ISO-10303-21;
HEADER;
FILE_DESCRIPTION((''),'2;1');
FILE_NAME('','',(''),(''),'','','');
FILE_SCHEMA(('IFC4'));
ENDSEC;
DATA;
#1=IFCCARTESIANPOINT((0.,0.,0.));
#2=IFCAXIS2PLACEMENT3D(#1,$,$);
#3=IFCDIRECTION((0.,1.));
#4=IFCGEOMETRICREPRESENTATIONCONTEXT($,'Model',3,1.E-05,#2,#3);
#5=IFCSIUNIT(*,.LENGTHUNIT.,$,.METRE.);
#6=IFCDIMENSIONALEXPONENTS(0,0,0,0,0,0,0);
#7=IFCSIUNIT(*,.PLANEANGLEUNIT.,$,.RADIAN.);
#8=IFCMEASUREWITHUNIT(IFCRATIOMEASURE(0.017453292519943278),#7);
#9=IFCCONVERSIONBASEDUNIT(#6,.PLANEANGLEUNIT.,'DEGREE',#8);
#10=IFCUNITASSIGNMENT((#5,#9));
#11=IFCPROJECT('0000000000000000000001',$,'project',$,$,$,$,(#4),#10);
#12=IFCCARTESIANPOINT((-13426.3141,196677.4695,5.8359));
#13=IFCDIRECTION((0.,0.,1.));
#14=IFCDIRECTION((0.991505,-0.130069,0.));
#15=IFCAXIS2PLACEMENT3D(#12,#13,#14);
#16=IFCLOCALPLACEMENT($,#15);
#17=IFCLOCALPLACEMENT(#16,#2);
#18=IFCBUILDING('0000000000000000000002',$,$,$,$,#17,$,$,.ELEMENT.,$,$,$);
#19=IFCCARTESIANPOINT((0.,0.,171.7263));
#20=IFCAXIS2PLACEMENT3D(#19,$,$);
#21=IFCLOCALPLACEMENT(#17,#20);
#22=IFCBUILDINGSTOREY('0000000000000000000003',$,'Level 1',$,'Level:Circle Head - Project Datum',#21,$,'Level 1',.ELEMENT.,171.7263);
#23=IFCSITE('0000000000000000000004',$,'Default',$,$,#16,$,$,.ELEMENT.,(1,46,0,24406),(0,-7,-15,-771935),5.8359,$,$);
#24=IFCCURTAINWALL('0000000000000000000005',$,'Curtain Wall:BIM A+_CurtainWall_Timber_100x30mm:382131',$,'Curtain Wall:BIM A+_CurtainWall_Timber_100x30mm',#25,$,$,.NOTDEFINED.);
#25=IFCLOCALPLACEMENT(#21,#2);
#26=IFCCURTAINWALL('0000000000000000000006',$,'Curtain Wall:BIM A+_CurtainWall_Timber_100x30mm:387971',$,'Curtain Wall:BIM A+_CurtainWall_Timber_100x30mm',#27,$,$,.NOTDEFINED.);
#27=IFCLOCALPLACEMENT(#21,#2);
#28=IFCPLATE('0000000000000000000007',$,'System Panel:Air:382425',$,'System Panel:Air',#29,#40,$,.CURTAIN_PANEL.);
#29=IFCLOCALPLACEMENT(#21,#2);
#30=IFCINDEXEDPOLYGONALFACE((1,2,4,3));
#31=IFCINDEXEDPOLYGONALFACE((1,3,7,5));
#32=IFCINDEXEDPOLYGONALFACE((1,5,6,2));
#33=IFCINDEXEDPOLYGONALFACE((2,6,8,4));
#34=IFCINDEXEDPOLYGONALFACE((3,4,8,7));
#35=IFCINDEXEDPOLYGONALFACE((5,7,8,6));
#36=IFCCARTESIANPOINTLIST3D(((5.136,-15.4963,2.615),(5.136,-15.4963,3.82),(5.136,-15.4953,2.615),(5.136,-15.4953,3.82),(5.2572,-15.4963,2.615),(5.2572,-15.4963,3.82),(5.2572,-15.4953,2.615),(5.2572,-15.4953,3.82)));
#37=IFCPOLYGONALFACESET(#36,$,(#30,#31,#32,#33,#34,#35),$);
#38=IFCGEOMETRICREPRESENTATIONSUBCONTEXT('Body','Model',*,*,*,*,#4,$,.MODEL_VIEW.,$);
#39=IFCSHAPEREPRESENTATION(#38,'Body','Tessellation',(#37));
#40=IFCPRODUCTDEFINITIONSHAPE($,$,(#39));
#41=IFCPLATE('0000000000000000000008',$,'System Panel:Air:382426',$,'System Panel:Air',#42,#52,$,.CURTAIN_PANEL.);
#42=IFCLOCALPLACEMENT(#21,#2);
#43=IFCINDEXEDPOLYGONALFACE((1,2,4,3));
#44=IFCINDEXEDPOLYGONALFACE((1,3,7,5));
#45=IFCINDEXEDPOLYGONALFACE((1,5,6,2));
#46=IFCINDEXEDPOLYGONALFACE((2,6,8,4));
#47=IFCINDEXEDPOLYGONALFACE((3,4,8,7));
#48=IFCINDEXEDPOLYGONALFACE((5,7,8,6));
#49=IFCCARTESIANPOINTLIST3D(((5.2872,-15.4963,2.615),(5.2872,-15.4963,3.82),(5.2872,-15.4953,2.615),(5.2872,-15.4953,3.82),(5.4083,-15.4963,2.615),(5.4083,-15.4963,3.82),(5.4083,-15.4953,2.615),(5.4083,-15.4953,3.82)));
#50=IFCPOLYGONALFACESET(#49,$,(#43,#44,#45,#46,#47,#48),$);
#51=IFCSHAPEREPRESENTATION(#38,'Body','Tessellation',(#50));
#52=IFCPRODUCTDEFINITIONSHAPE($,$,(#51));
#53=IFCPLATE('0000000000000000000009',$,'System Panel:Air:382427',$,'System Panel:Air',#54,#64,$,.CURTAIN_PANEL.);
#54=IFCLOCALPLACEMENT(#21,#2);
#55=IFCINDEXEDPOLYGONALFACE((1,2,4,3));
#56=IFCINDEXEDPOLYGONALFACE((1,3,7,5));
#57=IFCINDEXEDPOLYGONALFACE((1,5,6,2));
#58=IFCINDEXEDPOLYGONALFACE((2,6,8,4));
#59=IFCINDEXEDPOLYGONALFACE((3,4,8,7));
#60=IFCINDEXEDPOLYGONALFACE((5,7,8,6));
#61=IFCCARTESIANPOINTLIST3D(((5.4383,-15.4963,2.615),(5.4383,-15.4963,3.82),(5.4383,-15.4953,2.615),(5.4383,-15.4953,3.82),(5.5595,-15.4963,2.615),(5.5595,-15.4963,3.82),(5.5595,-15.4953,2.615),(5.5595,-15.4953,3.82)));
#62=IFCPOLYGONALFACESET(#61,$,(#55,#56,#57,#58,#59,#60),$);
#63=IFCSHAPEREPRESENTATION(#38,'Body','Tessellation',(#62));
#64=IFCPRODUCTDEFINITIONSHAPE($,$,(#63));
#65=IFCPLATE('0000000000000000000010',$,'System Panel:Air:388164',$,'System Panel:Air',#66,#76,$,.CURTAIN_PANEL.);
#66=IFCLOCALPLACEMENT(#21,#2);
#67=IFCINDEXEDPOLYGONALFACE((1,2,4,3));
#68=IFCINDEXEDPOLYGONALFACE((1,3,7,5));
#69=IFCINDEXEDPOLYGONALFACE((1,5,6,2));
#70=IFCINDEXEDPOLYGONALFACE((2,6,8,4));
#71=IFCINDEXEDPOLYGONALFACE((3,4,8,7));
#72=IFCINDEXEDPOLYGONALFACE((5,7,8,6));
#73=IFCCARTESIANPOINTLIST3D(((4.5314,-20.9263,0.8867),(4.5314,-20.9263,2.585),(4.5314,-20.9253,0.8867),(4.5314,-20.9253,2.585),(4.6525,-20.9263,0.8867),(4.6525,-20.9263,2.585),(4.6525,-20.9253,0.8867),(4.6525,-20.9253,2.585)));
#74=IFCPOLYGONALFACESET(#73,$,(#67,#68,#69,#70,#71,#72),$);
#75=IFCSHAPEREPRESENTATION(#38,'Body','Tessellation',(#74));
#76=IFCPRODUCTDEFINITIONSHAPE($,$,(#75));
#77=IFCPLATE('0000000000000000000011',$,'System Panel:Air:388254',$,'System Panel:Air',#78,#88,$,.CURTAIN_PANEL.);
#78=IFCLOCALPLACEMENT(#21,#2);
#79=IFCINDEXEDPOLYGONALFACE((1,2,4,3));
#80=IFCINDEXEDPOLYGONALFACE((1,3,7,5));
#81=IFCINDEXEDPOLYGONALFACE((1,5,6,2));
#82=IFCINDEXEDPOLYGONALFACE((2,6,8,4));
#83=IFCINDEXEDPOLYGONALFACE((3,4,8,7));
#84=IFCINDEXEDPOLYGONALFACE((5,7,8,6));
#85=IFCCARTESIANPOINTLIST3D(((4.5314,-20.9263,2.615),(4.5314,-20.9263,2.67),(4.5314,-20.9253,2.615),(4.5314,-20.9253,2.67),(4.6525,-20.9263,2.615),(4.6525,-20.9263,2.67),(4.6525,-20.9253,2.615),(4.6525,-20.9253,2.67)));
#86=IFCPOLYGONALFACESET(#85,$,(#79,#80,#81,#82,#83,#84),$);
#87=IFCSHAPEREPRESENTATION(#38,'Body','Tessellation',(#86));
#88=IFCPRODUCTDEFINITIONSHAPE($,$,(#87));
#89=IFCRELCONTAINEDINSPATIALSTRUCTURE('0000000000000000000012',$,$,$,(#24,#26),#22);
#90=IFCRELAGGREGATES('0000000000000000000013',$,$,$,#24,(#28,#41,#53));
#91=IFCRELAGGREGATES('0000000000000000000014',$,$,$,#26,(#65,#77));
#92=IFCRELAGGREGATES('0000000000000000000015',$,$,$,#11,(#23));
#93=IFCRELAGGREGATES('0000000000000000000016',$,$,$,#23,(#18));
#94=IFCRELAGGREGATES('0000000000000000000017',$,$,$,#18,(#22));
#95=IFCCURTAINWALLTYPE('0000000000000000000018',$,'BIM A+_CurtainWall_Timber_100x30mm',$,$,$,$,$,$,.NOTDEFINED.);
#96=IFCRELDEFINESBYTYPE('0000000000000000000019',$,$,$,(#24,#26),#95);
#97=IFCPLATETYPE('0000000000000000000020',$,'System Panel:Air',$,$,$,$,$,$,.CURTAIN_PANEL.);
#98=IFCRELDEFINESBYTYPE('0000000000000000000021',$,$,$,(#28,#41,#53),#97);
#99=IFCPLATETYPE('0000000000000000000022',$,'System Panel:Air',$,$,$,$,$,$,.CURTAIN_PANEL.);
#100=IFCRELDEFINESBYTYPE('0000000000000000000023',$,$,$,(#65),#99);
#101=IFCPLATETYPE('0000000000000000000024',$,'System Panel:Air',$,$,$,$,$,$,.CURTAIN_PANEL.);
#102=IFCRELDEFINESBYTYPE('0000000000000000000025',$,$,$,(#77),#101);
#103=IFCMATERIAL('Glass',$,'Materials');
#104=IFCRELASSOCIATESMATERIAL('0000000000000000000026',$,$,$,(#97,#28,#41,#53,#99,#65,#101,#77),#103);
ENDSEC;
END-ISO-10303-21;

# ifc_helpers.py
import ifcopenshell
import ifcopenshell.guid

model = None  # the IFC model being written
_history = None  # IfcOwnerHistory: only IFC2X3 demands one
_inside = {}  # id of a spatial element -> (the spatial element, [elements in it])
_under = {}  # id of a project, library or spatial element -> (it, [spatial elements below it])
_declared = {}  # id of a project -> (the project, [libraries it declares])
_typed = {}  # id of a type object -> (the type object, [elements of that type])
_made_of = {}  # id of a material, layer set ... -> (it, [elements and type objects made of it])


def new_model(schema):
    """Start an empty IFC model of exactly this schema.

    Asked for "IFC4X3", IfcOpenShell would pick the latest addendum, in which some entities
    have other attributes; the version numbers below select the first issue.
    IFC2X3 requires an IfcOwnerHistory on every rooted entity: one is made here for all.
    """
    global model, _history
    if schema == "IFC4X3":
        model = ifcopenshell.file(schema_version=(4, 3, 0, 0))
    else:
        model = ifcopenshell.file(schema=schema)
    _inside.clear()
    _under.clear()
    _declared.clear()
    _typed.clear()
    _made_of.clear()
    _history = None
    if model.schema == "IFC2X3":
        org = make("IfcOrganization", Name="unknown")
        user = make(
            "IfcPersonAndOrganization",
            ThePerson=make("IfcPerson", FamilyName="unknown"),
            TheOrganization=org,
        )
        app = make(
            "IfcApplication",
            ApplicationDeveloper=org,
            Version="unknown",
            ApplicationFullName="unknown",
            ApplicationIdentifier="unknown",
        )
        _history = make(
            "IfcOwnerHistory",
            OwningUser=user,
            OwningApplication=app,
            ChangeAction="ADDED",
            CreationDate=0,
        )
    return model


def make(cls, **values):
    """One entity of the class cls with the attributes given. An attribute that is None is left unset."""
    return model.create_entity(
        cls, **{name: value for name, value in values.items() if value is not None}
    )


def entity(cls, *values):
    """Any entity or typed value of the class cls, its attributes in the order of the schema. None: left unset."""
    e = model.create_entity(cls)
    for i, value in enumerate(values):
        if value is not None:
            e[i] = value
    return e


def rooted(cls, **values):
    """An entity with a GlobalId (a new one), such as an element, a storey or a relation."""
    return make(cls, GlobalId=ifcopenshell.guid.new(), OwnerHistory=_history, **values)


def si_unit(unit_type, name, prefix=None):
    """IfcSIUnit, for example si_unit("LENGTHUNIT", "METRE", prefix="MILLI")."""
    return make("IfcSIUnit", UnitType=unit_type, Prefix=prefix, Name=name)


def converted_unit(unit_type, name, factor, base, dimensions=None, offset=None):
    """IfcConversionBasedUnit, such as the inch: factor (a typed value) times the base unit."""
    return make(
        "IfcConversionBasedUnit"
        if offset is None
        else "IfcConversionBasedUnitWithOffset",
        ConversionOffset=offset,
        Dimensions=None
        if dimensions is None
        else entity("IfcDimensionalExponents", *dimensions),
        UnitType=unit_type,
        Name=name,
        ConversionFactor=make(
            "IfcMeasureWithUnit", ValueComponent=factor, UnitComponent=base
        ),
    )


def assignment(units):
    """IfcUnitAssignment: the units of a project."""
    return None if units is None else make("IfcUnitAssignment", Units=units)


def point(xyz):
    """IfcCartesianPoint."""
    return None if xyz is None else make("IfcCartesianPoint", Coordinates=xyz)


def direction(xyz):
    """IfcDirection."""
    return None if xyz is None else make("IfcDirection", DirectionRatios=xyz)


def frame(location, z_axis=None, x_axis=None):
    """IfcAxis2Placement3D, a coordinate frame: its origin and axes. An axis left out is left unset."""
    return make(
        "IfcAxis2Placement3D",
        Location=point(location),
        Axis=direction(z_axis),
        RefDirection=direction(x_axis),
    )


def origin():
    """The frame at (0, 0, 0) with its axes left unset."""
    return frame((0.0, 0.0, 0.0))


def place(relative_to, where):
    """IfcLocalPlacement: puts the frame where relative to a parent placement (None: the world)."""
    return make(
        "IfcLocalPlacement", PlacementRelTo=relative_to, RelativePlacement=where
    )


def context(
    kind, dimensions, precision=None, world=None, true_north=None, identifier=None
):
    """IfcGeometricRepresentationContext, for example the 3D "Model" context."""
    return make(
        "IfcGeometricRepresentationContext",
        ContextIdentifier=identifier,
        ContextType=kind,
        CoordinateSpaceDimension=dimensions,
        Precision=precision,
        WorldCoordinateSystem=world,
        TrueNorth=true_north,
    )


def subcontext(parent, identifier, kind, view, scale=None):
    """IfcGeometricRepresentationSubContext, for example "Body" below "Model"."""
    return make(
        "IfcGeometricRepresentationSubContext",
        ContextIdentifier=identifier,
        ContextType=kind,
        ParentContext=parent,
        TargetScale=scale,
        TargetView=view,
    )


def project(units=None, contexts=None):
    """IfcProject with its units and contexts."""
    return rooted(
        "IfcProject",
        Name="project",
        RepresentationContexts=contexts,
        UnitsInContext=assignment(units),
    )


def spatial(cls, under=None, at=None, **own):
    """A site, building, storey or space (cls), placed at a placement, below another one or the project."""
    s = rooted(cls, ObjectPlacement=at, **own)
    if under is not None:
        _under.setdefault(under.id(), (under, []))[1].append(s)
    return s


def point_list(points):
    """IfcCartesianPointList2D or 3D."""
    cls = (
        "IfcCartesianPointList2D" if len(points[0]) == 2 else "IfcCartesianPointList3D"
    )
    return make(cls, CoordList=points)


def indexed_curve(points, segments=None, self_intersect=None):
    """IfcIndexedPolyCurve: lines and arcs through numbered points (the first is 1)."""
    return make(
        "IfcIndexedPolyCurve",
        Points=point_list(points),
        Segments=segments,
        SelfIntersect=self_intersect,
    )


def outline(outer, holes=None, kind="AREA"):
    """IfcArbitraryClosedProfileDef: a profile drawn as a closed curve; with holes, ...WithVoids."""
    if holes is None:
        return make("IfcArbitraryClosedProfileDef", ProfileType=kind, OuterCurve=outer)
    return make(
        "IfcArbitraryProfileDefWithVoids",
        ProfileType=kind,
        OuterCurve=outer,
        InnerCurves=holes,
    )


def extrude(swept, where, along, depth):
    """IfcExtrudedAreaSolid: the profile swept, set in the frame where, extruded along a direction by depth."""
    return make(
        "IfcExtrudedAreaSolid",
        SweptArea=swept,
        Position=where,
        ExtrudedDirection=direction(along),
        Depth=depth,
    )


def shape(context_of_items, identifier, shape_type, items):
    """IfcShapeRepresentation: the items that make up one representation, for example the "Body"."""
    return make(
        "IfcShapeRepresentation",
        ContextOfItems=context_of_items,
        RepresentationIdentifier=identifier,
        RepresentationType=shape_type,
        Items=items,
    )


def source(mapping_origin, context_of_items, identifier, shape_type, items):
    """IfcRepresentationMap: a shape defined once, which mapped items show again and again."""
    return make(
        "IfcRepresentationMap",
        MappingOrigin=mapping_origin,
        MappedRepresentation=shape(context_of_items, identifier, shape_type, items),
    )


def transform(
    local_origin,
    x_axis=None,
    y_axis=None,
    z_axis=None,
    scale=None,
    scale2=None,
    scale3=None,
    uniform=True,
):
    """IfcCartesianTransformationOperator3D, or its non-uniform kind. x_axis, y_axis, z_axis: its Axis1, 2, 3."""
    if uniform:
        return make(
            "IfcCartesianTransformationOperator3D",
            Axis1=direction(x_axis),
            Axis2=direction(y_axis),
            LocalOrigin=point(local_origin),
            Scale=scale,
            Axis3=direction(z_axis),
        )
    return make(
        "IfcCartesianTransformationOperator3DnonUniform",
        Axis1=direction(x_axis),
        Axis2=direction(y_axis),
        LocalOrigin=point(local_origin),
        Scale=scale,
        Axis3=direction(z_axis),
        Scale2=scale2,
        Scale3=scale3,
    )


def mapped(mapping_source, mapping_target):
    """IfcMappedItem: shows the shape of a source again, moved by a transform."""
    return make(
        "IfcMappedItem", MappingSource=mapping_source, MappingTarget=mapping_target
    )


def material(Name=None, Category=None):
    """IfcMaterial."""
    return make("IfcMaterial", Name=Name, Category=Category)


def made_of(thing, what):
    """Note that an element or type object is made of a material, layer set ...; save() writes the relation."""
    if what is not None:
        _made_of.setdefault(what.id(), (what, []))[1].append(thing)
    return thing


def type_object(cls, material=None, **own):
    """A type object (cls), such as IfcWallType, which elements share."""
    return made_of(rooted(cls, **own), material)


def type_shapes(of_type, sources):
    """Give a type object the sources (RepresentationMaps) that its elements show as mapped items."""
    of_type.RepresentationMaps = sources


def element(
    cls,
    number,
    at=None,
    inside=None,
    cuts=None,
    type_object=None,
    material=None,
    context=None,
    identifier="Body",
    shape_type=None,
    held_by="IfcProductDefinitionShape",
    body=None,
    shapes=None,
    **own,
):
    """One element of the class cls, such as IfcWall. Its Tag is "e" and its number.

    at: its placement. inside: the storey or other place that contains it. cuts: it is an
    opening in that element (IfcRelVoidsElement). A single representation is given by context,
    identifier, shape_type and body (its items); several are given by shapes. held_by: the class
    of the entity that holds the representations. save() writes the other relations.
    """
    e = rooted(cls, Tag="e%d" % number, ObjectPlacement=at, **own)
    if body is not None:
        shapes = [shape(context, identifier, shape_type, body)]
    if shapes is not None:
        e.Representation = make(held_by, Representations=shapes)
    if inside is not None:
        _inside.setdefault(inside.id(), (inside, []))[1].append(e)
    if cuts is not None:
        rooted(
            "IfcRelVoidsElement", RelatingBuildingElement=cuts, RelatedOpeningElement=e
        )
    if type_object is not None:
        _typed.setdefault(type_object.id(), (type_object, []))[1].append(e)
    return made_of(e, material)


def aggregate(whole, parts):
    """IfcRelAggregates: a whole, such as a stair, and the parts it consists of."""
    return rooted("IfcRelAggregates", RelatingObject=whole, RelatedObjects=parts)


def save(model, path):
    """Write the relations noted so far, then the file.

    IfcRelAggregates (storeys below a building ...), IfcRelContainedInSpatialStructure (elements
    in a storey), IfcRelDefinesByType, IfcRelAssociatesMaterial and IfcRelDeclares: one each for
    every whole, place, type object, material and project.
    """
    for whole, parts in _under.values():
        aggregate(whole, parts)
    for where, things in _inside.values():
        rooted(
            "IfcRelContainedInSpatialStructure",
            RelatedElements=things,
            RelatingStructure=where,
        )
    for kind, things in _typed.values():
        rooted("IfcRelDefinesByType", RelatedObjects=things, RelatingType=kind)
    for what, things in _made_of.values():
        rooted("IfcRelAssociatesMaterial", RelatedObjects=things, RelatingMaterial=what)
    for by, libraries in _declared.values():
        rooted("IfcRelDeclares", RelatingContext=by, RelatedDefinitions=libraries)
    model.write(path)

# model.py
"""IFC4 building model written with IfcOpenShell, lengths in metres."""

from ifc_helpers import new_model, entity, si_unit, converted_unit, direction, frame, origin, place, context, subcontext, project, spatial, indexed_curve, outline, extrude, source, transform, mapped, material, type_object, type_shapes, element, aggregate, save


model = new_model("IFC4")

# Units and contexts
model_context = context("Model", 3, precision=1e-05, world=origin(), true_north=direction((0.0, 1.0)))
body_context = subcontext(model_context, "Body", "Model", "MODEL_VIEW")
ifc_project = project(units=[si_unit("LENGTHUNIT", "METRE"), converted_unit("PLANEANGLEUNIT", "DEGREE", entity("IfcRatioMeasure", 0.017453292519943278), si_unit("PLANEANGLEUNIT", "RADIAN"), dimensions=[0, 0, 0, 0, 0, 0, 0])], contexts=[model_context])

# Site, building, storey
site_placement = place(None, frame((-13426.3141, 196677.4695, 5.8359), z_axis=(0.0, 0.0, 1.0), x_axis=(0.991505, -0.130069, 0.0)))
site = spatial("IfcSite", under=ifc_project, at=site_placement, Name="Default", CompositionType="ELEMENT", RefLatitude=(1, 46, 0, 24406), RefLongitude=(0, -7, -15, -771935), RefElevation=5.8359)
building_placement = place(site_placement, origin())
building = spatial("IfcBuilding", under=site, at=building_placement, CompositionType="ELEMENT")
storey_placement = place(building_placement, frame((0.0, 0.0, 171.7263)))
storey = spatial("IfcBuildingStorey", under=building, at=storey_placement, Name="Level 1", ObjectType="Level:Circle Head - Project Datum", LongName="Level 1", CompositionType="ELEMENT", Elevation=171.7263)

# Curtain walls
curtain_wall_type_1 = type_object("IfcCurtainWallType", Name="BIM A+_CurtainWall_Timber_100x30mm", PredefinedType="NOTDEFINED")
curtain_wall_1_placement = place(storey_placement, frame((0.0, 0.0, -171.7263)))
curtain_wall_1 = element("IfcCurtainWall", 1, at=curtain_wall_1_placement, inside=storey, type_object=curtain_wall_type_1, Name="Curtain Wall:BIM A+_CurtainWall_Timber_100x30mm:382131", ObjectType="Curtain Wall:BIM A+_CurtainWall_Timber_100x30mm", PredefinedType="NOTDEFINED")
curtain_wall_2_placement = place(storey_placement, frame((0.0, 0.0, -171.7263)))
curtain_wall_2 = element("IfcCurtainWall", 2, at=curtain_wall_2_placement, inside=storey, type_object=curtain_wall_type_1, Name="Curtain Wall:BIM A+_CurtainWall_Timber_100x30mm:387971", ObjectType="Curtain Wall:BIM A+_CurtainWall_Timber_100x30mm", PredefinedType="NOTDEFINED")

# Plates
ifc_material_1 = material(Name="Glass", Category="Materials")
plate_type_1 = type_object("IfcPlateType", Name="System Panel:Air", PredefinedType="CURTAIN_PANEL", material=ifc_material_1)
shared_shape_1 = source(origin(), body_context, "Body", "SweptSolid", [
    extrude(outline(indexed_curve([(-0.0005, -0.0606), (0.0005, -0.0606), (0.0005, 0.0606), (-0.0005, 0.0606), (-0.0005, -0.0606)], self_intersect=False)), frame((0.0, 0.0, 0.0), z_axis=(0.0, 0.0, 1.0), x_axis=(0.0, 1.0, 0.0)), (0.0, 0.0, 1.0), 1.205),
])
type_shapes(plate_type_1, [shared_shape_1])
plate_1_placement = place(curtain_wall_1_placement, frame((5.1966, -15.4958, 174.3413)))
plate_1 = element("IfcPlate", 3, at=plate_1_placement, type_object=plate_type_1, material=ifc_material_1, Name="System Panel:Air:382425", ObjectType="System Panel:Air", PredefinedType="CURTAIN_PANEL", context=body_context, shape_type="MappedRepresentation", body=[
    mapped(shared_shape_1, transform((0.0, 0.0, 0.0), scale=1.0)),
])
plate_2_placement = place(curtain_wall_1_placement, frame((5.3477, -15.4958, 174.3413)))
plate_2 = element("IfcPlate", 4, at=plate_2_placement, type_object=plate_type_1, material=ifc_material_1, Name="System Panel:Air:382426", ObjectType="System Panel:Air", PredefinedType="CURTAIN_PANEL", context=body_context, shape_type="MappedRepresentation", body=[
    mapped(shared_shape_1, transform((0.0, 0.0, 0.0), scale=1.0)),
])
plate_3_placement = place(curtain_wall_1_placement, frame((5.4989, -15.4958, 174.3413)))
plate_3 = element("IfcPlate", 5, at=plate_3_placement, type_object=plate_type_1, material=ifc_material_1, Name="System Panel:Air:382427", ObjectType="System Panel:Air", PredefinedType="CURTAIN_PANEL", context=body_context, shape_type="MappedRepresentation", body=[
    mapped(shared_shape_1, transform((0.0, 0.0, 0.0), scale=1.0)),
])
aggregate(curtain_wall_1, [plate_1, plate_2, plate_3])
plate_type_2 = type_object("IfcPlateType", Name="System Panel:Air", PredefinedType="CURTAIN_PANEL", material=ifc_material_1)
shared_shape_2 = source(origin(), body_context, "Body", "SweptSolid", [
    extrude(outline(indexed_curve([(-0.0005, -0.0606), (0.0005, -0.0606), (0.0005, 0.0606), (-0.0005, 0.0606), (-0.0005, -0.0606)], self_intersect=False)), frame((0.0, 0.0, 0.0), z_axis=(0.0, 0.0, 1.0), x_axis=(0.0, 1.0, 0.0)), (0.0, 0.0, 1.0), 1.6983),
])
type_shapes(plate_type_2, [shared_shape_2])
plate_4_placement = place(curtain_wall_2_placement, frame((4.5919, -20.9258, 172.613)))
plate_4 = element("IfcPlate", 6, at=plate_4_placement, type_object=plate_type_2, material=ifc_material_1, Name="System Panel:Air:388164", ObjectType="System Panel:Air", PredefinedType="CURTAIN_PANEL", context=body_context, shape_type="MappedRepresentation", body=[
    mapped(shared_shape_2, transform((0.0, 0.0, 0.0), scale=1.0)),
])
plate_type_3 = type_object("IfcPlateType", Name="System Panel:Air", PredefinedType="CURTAIN_PANEL", material=ifc_material_1)
shared_shape_3 = source(origin(), body_context, "Body", "SweptSolid", [
    extrude(outline(indexed_curve([(-0.0005, -0.0606), (0.0005, -0.0606), (0.0005, 0.0606), (-0.0005, 0.0606), (-0.0005, -0.0606)], self_intersect=False)), frame((0.0, 0.0, 0.0), z_axis=(0.0, 0.0, 1.0), x_axis=(0.0, 1.0, 0.0)), (0.0, 0.0, 1.0), 0.055),
])
type_shapes(plate_type_3, [shared_shape_3])
plate_5_placement = place(curtain_wall_2_placement, frame((4.5919, -20.9258, 174.3413)))
plate_5 = element("IfcPlate", 7, at=plate_5_placement, type_object=plate_type_3, material=ifc_material_1, Name="System Panel:Air:388254", ObjectType="System Panel:Air", PredefinedType="CURTAIN_PANEL", context=body_context, shape_type="MappedRepresentation", body=[
    mapped(shared_shape_3, transform((0.0, 0.0, 0.0), scale=1.0)),
])
aggregate(curtain_wall_2, [plate_4, plate_5])

save(model, "model.ifc")
